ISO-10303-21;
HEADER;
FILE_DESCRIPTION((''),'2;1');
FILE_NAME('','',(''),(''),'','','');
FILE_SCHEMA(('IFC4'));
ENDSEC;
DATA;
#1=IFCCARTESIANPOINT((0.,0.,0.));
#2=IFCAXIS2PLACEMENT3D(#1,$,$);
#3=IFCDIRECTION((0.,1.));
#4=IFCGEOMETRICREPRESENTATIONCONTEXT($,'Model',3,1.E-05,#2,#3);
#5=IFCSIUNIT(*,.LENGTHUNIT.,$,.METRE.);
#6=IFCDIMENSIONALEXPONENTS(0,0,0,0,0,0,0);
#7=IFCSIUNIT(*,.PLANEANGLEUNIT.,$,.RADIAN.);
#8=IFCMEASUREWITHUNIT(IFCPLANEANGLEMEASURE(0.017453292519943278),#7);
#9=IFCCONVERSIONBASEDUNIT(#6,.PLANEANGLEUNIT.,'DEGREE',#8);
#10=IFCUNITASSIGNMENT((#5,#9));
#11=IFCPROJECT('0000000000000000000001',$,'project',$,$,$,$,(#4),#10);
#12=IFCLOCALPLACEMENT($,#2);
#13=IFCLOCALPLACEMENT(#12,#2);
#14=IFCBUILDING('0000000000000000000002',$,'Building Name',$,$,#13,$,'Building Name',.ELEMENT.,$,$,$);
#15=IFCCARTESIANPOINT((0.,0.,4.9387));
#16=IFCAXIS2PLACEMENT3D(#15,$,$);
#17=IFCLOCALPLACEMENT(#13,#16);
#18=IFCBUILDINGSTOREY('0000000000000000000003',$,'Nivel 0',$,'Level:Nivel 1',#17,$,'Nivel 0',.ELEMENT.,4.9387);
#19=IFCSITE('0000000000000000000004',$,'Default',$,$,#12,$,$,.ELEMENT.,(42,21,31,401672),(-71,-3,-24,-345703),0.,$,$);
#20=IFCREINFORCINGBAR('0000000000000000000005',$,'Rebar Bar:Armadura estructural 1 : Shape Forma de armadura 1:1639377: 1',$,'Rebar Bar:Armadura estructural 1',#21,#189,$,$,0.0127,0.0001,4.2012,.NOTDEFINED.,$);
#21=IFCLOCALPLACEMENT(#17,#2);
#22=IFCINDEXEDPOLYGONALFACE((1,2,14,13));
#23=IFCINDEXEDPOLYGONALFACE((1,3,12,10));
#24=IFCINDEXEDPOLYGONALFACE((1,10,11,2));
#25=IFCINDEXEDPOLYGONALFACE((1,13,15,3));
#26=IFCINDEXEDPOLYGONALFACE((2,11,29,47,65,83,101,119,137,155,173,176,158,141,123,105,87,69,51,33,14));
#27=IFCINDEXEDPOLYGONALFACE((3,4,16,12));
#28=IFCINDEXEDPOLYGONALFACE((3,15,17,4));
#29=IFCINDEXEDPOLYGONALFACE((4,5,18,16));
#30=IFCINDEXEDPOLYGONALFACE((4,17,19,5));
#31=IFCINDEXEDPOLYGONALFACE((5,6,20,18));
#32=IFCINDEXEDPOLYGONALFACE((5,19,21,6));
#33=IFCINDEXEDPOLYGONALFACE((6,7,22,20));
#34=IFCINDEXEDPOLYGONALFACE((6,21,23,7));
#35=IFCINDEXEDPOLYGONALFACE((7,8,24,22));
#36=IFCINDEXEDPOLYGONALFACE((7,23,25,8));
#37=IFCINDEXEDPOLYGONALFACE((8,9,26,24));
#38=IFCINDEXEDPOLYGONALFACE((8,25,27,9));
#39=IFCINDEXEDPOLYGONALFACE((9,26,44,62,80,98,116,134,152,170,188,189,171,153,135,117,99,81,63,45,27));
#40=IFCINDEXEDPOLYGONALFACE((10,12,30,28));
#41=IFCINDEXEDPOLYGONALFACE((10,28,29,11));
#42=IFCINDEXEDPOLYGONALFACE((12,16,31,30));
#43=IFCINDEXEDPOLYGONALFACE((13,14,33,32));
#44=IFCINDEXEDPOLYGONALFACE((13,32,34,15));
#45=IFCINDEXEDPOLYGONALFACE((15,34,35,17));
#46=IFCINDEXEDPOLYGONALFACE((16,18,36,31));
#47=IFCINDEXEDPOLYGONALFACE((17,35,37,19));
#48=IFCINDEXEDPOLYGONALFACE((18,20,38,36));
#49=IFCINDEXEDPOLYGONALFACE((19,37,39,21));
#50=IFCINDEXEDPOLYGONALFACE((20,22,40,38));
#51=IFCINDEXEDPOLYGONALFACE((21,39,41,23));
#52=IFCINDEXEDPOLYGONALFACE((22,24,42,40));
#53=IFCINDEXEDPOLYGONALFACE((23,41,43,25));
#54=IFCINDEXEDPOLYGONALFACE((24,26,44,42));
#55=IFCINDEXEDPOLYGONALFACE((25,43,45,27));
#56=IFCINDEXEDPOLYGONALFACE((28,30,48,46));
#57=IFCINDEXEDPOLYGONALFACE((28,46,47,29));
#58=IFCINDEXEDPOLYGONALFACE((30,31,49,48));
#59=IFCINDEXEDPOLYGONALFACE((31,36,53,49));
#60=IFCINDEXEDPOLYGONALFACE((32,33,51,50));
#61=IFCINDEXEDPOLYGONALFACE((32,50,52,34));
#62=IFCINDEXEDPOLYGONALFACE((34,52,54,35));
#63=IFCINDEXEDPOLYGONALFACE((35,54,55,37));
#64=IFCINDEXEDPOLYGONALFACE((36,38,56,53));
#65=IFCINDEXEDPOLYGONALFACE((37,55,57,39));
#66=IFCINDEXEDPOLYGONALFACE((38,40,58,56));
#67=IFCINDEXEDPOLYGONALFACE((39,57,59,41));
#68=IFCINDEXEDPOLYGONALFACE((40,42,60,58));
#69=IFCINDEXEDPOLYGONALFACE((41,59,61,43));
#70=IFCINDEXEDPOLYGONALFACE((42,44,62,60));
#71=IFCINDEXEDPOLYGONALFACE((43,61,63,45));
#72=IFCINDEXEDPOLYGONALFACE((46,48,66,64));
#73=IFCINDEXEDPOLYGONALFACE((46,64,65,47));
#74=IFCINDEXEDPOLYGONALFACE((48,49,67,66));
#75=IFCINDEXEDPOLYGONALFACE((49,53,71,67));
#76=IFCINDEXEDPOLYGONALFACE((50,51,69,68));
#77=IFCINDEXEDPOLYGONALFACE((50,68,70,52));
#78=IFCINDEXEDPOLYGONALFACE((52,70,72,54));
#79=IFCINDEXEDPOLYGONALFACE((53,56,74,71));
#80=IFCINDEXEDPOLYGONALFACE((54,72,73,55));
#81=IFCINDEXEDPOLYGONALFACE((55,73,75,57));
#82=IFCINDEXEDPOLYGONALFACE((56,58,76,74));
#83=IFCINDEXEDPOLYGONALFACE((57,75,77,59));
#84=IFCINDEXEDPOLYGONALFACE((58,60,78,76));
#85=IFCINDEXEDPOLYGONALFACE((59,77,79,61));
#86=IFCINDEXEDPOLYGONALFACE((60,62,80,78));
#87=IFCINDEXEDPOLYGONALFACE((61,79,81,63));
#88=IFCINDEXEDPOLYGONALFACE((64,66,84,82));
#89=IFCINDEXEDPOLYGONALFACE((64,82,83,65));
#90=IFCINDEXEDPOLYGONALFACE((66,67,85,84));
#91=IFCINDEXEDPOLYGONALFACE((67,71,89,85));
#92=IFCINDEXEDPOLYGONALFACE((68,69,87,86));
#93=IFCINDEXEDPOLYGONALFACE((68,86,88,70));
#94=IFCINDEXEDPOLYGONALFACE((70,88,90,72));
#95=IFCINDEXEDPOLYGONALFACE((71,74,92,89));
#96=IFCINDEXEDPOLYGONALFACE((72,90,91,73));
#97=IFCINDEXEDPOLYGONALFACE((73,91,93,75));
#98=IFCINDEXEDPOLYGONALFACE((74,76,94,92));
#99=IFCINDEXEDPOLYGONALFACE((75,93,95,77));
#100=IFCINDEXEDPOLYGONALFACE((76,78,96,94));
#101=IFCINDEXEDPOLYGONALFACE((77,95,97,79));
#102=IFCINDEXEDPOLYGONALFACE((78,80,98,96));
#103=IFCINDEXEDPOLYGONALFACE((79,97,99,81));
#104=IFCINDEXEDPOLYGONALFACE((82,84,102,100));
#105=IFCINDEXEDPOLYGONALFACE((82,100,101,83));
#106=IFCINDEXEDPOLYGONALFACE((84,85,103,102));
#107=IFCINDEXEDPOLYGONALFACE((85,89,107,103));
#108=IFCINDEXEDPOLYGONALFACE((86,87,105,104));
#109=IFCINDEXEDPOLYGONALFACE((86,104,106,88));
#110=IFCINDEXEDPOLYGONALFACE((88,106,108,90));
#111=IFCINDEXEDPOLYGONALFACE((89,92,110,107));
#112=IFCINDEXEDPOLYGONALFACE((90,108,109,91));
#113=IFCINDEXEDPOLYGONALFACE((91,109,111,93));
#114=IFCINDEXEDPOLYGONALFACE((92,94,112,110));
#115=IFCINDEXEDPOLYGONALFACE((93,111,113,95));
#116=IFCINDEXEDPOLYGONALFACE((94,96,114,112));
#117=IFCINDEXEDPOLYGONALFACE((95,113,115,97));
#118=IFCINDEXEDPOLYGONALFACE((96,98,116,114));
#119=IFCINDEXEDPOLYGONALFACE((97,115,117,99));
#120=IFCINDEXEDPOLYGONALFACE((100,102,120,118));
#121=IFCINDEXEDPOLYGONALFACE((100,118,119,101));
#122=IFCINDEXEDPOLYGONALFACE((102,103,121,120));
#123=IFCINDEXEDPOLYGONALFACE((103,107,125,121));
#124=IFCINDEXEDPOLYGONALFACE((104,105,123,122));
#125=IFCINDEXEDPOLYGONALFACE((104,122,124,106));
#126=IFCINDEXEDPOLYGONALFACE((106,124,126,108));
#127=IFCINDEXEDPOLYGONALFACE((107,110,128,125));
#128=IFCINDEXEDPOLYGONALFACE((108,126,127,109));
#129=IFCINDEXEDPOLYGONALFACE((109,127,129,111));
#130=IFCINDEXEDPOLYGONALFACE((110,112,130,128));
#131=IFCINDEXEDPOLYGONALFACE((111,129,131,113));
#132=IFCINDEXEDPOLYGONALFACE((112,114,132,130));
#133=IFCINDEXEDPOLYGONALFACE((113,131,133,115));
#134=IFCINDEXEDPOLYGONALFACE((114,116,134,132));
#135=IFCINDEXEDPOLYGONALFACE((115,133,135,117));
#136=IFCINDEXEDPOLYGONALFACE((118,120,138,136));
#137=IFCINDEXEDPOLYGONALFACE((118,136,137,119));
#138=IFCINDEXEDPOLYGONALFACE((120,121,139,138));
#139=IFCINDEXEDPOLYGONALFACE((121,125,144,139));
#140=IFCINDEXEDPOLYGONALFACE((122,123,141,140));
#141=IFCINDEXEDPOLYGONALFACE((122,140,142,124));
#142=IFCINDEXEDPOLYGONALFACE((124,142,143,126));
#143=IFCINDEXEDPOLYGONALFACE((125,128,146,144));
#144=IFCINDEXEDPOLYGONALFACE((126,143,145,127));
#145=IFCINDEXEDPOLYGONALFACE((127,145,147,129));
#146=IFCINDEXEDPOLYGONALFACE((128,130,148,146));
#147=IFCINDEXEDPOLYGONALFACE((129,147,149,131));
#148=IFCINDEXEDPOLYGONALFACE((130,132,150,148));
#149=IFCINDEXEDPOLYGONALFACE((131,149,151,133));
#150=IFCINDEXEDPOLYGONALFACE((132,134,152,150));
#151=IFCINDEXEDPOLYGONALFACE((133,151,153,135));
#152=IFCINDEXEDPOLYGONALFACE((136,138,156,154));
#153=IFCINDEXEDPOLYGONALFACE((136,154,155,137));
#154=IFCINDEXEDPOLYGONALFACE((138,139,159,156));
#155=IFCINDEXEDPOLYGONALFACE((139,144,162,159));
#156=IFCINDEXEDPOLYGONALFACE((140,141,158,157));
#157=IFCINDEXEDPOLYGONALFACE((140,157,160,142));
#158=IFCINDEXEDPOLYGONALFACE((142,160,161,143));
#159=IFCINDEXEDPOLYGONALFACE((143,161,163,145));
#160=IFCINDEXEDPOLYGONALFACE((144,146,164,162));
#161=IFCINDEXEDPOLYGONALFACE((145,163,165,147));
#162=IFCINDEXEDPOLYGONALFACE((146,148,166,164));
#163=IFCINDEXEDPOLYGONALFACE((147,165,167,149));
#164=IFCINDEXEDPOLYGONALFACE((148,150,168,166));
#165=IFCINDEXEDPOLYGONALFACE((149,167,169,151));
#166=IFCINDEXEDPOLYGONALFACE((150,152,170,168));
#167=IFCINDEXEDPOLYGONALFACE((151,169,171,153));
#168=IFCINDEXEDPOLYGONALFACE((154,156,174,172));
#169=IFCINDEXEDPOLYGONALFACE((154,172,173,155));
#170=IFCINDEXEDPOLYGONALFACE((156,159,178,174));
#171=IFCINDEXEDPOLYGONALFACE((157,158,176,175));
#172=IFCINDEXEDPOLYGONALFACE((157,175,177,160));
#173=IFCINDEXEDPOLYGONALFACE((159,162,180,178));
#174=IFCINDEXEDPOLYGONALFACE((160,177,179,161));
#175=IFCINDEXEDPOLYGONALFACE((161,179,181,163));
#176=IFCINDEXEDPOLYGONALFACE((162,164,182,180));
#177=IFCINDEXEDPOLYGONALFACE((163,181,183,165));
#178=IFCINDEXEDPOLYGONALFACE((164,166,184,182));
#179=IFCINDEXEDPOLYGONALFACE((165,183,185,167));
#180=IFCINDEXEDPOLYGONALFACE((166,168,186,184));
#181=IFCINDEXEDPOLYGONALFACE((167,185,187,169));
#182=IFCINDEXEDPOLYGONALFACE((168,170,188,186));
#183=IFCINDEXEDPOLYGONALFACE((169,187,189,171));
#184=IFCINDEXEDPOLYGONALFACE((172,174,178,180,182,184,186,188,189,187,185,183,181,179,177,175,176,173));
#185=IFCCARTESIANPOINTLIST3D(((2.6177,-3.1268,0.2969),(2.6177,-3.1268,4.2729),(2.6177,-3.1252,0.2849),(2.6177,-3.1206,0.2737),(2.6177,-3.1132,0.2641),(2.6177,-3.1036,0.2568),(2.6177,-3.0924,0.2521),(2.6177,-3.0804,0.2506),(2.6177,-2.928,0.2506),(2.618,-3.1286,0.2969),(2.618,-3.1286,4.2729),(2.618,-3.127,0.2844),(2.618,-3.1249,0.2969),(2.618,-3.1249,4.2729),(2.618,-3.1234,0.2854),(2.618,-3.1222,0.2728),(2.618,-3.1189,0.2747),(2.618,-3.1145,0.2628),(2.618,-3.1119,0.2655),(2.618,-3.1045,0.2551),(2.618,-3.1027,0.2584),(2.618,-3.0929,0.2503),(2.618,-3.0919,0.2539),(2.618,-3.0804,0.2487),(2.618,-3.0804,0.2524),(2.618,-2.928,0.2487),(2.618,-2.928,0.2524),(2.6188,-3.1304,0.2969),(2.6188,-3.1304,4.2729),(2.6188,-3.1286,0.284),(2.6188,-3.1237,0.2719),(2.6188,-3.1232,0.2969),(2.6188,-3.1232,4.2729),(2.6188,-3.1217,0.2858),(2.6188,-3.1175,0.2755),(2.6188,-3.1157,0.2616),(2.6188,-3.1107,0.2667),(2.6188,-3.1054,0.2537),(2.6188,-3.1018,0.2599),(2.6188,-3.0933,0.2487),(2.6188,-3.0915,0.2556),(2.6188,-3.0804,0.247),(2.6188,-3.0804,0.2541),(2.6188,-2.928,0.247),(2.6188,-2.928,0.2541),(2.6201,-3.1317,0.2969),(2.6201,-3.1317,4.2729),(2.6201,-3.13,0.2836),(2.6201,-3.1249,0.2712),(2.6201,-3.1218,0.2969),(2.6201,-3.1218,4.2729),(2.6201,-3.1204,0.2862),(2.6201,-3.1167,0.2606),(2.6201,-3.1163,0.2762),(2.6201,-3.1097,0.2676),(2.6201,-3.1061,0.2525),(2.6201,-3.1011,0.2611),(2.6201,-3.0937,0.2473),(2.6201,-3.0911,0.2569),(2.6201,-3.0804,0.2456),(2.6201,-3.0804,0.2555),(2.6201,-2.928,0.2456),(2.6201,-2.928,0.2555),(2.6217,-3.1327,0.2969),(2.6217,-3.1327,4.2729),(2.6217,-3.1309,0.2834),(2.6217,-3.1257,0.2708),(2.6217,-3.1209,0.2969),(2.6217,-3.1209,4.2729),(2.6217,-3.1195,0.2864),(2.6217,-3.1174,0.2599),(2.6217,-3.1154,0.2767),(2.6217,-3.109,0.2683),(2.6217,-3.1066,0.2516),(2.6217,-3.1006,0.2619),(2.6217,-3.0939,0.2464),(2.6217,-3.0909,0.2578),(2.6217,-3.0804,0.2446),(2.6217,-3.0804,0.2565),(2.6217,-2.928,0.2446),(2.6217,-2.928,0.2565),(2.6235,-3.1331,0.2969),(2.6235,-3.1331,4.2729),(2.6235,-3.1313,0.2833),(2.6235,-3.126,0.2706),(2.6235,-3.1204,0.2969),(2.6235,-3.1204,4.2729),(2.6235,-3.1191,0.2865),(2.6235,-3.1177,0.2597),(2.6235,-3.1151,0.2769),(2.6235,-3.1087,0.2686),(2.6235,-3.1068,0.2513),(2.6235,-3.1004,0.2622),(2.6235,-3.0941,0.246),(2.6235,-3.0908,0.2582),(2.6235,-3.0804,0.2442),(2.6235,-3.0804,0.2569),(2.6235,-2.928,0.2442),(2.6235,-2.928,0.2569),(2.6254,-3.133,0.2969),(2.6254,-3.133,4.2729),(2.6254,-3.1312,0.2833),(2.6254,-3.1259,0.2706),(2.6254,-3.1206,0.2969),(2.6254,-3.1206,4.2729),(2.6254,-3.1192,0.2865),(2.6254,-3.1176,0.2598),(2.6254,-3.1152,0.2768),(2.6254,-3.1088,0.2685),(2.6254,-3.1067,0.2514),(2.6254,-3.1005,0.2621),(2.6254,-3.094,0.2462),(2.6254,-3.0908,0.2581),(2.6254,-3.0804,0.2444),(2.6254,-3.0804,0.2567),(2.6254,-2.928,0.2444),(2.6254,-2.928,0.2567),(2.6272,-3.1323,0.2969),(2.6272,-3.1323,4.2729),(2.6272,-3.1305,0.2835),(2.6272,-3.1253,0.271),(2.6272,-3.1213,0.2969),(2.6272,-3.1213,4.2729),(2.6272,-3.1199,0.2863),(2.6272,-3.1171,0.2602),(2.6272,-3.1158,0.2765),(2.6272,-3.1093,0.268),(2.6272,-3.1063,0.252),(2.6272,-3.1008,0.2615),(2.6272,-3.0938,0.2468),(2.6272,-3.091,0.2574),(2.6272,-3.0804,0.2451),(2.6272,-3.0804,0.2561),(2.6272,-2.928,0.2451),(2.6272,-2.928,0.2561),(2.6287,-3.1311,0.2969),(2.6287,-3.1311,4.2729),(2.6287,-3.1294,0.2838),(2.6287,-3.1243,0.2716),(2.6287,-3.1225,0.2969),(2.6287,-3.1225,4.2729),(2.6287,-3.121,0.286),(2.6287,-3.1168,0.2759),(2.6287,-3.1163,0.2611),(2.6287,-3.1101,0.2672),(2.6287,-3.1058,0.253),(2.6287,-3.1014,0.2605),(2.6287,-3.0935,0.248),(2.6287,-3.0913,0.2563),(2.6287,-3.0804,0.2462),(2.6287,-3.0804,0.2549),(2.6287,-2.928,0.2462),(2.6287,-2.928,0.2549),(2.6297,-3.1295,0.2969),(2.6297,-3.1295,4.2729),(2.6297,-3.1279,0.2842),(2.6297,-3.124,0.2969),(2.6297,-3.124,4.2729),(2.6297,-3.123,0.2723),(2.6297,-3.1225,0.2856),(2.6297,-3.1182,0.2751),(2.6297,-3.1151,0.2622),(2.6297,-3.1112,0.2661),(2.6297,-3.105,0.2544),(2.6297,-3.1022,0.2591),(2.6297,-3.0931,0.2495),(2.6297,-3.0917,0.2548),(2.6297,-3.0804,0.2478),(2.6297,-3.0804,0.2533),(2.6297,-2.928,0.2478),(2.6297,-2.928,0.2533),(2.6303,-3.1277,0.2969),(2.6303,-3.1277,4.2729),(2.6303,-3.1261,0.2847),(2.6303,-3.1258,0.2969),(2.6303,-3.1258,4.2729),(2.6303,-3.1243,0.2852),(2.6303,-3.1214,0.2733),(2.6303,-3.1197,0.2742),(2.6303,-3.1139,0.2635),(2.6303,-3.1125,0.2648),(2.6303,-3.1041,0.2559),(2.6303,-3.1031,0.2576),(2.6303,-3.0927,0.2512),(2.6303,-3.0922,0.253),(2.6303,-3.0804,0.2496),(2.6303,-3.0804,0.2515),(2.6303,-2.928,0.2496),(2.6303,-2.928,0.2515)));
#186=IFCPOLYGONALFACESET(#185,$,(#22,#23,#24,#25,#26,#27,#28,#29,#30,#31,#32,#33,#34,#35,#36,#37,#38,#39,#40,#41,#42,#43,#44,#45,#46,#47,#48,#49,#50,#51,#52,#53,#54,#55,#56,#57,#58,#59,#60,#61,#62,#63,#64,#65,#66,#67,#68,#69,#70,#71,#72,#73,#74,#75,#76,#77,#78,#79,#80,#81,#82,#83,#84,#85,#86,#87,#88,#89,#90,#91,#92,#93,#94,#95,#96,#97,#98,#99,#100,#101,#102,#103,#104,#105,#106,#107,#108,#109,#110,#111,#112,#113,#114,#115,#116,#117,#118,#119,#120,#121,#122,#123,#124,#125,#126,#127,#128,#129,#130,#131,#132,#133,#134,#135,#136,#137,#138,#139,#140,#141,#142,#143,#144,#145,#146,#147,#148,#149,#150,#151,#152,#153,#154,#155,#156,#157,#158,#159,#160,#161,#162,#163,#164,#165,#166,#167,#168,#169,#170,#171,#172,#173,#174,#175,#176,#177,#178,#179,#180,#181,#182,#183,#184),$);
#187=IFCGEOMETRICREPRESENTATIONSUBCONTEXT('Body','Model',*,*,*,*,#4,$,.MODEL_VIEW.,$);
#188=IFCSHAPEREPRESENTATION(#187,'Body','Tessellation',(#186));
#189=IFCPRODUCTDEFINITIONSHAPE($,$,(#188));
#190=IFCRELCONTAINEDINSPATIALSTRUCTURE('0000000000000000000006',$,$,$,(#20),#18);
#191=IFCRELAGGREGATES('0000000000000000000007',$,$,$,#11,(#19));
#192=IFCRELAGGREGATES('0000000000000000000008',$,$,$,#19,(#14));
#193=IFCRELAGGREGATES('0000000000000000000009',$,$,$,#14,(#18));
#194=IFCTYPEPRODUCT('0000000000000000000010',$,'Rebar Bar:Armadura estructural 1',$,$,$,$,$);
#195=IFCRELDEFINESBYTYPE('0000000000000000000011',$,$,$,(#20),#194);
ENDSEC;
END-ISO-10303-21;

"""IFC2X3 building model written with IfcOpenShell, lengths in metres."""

from ifc_helpers import new_model, entity, si_unit, converted_unit, direction, frame, origin, place, context, subcontext, project, spatial, type_object, element, save


model = new_model("IFC2X3")

# Units and contexts
model_context = context("Model", 3, precision=1e-05, world=origin(), true_north=direction((0.0, 1.0)))
body_context = subcontext(model_context, "Body", "Model", "MODEL_VIEW")
ifc_project = project(units=[si_unit("LENGTHUNIT", "METRE"), converted_unit("PLANEANGLEUNIT", "DEGREE", entity("IfcPlaneAngleMeasure", 0.017453292519943278), si_unit("PLANEANGLEUNIT", "RADIAN"), dimensions=[0, 0, 0, 0, 0, 0, 0])], contexts=[model_context])

# Site, building, storey
site_placement = place(None, origin())
site = spatial("IfcSite", under=ifc_project, at=site_placement, Name="Default", CompositionType="ELEMENT", RefLatitude=(42, 21, 31, 401672), RefLongitude=(-71, -3, -24, -345703), RefElevation=0.0)
building_placement = place(site_placement, origin())
building = spatial("IfcBuilding", under=site, at=building_placement, Name="Building Name", LongName="Building Name", CompositionType="ELEMENT")
storey_placement = place(building_placement, frame((0.0, 0.0, 4.9387)))
storey = spatial("IfcBuildingStorey", under=building, at=storey_placement, Name="Nivel 0", ObjectType="Level:Nivel 1", LongName="Nivel 0", CompositionType="ELEMENT", Elevation=4.9387)

# Reinforcing bar
type_product = type_object("IfcTypeProduct", Name="Rebar Bar:Armadura estructural 1")
reinforcing_bar_1_placement = place(storey_placement, origin())
element("IfcReinforcingBar", 1, at=reinforcing_bar_1_placement, inside=storey, type_object=type_product, Name="Rebar Bar:Armadura estructural 1 : Shape Forma de armadura 1:1639377: 1", ObjectType="Rebar Bar:Armadura estructural 1", BarLength=4.2012, BarRole="NOTDEFINED", CrossSectionArea=0.0001, NominalDiameter=0.0127, context=body_context, shape_type="AdvancedSweptSolid", body=[
    entity("IfcSweptDiskSolid", entity("IfcCompositeCurve", [entity("IfcCompositeCurveSegment", "CONTINUOUS", True, entity("IfcPolyline", [entity("IfcCartesianPoint", [2.624, -2.928, 0.2506]), entity("IfcCartesianPoint", [2.624, -3.0804, 0.2506])])), entity("IfcCompositeCurveSegment", "CONTINUOUS", True, entity("IfcTrimmedCurve", entity("IfcCircle", entity("IfcAxis2Placement3D", entity("IfcCartesianPoint", [2.624, -3.0804, 0.2969]), entity("IfcDirection", [-1.0, 0.0, 0.0]), entity("IfcDirection", [0.0, -1.0, 0.0])), 0.0464), [entity("IfcParameterValue", 270.0)], [entity("IfcParameterValue", 360.0)], True, "PARAMETER")), entity("IfcCompositeCurveSegment", "CONTINUOUS", True, entity("IfcPolyline", [entity("IfcCartesianPoint", [2.624, -3.1268, 0.2969]), entity("IfcCartesianPoint", [2.624, -3.1268, 4.2729])]))], False), 0.0063, None, 0.0, 92.0),
])

save(model, "model.ifc")
